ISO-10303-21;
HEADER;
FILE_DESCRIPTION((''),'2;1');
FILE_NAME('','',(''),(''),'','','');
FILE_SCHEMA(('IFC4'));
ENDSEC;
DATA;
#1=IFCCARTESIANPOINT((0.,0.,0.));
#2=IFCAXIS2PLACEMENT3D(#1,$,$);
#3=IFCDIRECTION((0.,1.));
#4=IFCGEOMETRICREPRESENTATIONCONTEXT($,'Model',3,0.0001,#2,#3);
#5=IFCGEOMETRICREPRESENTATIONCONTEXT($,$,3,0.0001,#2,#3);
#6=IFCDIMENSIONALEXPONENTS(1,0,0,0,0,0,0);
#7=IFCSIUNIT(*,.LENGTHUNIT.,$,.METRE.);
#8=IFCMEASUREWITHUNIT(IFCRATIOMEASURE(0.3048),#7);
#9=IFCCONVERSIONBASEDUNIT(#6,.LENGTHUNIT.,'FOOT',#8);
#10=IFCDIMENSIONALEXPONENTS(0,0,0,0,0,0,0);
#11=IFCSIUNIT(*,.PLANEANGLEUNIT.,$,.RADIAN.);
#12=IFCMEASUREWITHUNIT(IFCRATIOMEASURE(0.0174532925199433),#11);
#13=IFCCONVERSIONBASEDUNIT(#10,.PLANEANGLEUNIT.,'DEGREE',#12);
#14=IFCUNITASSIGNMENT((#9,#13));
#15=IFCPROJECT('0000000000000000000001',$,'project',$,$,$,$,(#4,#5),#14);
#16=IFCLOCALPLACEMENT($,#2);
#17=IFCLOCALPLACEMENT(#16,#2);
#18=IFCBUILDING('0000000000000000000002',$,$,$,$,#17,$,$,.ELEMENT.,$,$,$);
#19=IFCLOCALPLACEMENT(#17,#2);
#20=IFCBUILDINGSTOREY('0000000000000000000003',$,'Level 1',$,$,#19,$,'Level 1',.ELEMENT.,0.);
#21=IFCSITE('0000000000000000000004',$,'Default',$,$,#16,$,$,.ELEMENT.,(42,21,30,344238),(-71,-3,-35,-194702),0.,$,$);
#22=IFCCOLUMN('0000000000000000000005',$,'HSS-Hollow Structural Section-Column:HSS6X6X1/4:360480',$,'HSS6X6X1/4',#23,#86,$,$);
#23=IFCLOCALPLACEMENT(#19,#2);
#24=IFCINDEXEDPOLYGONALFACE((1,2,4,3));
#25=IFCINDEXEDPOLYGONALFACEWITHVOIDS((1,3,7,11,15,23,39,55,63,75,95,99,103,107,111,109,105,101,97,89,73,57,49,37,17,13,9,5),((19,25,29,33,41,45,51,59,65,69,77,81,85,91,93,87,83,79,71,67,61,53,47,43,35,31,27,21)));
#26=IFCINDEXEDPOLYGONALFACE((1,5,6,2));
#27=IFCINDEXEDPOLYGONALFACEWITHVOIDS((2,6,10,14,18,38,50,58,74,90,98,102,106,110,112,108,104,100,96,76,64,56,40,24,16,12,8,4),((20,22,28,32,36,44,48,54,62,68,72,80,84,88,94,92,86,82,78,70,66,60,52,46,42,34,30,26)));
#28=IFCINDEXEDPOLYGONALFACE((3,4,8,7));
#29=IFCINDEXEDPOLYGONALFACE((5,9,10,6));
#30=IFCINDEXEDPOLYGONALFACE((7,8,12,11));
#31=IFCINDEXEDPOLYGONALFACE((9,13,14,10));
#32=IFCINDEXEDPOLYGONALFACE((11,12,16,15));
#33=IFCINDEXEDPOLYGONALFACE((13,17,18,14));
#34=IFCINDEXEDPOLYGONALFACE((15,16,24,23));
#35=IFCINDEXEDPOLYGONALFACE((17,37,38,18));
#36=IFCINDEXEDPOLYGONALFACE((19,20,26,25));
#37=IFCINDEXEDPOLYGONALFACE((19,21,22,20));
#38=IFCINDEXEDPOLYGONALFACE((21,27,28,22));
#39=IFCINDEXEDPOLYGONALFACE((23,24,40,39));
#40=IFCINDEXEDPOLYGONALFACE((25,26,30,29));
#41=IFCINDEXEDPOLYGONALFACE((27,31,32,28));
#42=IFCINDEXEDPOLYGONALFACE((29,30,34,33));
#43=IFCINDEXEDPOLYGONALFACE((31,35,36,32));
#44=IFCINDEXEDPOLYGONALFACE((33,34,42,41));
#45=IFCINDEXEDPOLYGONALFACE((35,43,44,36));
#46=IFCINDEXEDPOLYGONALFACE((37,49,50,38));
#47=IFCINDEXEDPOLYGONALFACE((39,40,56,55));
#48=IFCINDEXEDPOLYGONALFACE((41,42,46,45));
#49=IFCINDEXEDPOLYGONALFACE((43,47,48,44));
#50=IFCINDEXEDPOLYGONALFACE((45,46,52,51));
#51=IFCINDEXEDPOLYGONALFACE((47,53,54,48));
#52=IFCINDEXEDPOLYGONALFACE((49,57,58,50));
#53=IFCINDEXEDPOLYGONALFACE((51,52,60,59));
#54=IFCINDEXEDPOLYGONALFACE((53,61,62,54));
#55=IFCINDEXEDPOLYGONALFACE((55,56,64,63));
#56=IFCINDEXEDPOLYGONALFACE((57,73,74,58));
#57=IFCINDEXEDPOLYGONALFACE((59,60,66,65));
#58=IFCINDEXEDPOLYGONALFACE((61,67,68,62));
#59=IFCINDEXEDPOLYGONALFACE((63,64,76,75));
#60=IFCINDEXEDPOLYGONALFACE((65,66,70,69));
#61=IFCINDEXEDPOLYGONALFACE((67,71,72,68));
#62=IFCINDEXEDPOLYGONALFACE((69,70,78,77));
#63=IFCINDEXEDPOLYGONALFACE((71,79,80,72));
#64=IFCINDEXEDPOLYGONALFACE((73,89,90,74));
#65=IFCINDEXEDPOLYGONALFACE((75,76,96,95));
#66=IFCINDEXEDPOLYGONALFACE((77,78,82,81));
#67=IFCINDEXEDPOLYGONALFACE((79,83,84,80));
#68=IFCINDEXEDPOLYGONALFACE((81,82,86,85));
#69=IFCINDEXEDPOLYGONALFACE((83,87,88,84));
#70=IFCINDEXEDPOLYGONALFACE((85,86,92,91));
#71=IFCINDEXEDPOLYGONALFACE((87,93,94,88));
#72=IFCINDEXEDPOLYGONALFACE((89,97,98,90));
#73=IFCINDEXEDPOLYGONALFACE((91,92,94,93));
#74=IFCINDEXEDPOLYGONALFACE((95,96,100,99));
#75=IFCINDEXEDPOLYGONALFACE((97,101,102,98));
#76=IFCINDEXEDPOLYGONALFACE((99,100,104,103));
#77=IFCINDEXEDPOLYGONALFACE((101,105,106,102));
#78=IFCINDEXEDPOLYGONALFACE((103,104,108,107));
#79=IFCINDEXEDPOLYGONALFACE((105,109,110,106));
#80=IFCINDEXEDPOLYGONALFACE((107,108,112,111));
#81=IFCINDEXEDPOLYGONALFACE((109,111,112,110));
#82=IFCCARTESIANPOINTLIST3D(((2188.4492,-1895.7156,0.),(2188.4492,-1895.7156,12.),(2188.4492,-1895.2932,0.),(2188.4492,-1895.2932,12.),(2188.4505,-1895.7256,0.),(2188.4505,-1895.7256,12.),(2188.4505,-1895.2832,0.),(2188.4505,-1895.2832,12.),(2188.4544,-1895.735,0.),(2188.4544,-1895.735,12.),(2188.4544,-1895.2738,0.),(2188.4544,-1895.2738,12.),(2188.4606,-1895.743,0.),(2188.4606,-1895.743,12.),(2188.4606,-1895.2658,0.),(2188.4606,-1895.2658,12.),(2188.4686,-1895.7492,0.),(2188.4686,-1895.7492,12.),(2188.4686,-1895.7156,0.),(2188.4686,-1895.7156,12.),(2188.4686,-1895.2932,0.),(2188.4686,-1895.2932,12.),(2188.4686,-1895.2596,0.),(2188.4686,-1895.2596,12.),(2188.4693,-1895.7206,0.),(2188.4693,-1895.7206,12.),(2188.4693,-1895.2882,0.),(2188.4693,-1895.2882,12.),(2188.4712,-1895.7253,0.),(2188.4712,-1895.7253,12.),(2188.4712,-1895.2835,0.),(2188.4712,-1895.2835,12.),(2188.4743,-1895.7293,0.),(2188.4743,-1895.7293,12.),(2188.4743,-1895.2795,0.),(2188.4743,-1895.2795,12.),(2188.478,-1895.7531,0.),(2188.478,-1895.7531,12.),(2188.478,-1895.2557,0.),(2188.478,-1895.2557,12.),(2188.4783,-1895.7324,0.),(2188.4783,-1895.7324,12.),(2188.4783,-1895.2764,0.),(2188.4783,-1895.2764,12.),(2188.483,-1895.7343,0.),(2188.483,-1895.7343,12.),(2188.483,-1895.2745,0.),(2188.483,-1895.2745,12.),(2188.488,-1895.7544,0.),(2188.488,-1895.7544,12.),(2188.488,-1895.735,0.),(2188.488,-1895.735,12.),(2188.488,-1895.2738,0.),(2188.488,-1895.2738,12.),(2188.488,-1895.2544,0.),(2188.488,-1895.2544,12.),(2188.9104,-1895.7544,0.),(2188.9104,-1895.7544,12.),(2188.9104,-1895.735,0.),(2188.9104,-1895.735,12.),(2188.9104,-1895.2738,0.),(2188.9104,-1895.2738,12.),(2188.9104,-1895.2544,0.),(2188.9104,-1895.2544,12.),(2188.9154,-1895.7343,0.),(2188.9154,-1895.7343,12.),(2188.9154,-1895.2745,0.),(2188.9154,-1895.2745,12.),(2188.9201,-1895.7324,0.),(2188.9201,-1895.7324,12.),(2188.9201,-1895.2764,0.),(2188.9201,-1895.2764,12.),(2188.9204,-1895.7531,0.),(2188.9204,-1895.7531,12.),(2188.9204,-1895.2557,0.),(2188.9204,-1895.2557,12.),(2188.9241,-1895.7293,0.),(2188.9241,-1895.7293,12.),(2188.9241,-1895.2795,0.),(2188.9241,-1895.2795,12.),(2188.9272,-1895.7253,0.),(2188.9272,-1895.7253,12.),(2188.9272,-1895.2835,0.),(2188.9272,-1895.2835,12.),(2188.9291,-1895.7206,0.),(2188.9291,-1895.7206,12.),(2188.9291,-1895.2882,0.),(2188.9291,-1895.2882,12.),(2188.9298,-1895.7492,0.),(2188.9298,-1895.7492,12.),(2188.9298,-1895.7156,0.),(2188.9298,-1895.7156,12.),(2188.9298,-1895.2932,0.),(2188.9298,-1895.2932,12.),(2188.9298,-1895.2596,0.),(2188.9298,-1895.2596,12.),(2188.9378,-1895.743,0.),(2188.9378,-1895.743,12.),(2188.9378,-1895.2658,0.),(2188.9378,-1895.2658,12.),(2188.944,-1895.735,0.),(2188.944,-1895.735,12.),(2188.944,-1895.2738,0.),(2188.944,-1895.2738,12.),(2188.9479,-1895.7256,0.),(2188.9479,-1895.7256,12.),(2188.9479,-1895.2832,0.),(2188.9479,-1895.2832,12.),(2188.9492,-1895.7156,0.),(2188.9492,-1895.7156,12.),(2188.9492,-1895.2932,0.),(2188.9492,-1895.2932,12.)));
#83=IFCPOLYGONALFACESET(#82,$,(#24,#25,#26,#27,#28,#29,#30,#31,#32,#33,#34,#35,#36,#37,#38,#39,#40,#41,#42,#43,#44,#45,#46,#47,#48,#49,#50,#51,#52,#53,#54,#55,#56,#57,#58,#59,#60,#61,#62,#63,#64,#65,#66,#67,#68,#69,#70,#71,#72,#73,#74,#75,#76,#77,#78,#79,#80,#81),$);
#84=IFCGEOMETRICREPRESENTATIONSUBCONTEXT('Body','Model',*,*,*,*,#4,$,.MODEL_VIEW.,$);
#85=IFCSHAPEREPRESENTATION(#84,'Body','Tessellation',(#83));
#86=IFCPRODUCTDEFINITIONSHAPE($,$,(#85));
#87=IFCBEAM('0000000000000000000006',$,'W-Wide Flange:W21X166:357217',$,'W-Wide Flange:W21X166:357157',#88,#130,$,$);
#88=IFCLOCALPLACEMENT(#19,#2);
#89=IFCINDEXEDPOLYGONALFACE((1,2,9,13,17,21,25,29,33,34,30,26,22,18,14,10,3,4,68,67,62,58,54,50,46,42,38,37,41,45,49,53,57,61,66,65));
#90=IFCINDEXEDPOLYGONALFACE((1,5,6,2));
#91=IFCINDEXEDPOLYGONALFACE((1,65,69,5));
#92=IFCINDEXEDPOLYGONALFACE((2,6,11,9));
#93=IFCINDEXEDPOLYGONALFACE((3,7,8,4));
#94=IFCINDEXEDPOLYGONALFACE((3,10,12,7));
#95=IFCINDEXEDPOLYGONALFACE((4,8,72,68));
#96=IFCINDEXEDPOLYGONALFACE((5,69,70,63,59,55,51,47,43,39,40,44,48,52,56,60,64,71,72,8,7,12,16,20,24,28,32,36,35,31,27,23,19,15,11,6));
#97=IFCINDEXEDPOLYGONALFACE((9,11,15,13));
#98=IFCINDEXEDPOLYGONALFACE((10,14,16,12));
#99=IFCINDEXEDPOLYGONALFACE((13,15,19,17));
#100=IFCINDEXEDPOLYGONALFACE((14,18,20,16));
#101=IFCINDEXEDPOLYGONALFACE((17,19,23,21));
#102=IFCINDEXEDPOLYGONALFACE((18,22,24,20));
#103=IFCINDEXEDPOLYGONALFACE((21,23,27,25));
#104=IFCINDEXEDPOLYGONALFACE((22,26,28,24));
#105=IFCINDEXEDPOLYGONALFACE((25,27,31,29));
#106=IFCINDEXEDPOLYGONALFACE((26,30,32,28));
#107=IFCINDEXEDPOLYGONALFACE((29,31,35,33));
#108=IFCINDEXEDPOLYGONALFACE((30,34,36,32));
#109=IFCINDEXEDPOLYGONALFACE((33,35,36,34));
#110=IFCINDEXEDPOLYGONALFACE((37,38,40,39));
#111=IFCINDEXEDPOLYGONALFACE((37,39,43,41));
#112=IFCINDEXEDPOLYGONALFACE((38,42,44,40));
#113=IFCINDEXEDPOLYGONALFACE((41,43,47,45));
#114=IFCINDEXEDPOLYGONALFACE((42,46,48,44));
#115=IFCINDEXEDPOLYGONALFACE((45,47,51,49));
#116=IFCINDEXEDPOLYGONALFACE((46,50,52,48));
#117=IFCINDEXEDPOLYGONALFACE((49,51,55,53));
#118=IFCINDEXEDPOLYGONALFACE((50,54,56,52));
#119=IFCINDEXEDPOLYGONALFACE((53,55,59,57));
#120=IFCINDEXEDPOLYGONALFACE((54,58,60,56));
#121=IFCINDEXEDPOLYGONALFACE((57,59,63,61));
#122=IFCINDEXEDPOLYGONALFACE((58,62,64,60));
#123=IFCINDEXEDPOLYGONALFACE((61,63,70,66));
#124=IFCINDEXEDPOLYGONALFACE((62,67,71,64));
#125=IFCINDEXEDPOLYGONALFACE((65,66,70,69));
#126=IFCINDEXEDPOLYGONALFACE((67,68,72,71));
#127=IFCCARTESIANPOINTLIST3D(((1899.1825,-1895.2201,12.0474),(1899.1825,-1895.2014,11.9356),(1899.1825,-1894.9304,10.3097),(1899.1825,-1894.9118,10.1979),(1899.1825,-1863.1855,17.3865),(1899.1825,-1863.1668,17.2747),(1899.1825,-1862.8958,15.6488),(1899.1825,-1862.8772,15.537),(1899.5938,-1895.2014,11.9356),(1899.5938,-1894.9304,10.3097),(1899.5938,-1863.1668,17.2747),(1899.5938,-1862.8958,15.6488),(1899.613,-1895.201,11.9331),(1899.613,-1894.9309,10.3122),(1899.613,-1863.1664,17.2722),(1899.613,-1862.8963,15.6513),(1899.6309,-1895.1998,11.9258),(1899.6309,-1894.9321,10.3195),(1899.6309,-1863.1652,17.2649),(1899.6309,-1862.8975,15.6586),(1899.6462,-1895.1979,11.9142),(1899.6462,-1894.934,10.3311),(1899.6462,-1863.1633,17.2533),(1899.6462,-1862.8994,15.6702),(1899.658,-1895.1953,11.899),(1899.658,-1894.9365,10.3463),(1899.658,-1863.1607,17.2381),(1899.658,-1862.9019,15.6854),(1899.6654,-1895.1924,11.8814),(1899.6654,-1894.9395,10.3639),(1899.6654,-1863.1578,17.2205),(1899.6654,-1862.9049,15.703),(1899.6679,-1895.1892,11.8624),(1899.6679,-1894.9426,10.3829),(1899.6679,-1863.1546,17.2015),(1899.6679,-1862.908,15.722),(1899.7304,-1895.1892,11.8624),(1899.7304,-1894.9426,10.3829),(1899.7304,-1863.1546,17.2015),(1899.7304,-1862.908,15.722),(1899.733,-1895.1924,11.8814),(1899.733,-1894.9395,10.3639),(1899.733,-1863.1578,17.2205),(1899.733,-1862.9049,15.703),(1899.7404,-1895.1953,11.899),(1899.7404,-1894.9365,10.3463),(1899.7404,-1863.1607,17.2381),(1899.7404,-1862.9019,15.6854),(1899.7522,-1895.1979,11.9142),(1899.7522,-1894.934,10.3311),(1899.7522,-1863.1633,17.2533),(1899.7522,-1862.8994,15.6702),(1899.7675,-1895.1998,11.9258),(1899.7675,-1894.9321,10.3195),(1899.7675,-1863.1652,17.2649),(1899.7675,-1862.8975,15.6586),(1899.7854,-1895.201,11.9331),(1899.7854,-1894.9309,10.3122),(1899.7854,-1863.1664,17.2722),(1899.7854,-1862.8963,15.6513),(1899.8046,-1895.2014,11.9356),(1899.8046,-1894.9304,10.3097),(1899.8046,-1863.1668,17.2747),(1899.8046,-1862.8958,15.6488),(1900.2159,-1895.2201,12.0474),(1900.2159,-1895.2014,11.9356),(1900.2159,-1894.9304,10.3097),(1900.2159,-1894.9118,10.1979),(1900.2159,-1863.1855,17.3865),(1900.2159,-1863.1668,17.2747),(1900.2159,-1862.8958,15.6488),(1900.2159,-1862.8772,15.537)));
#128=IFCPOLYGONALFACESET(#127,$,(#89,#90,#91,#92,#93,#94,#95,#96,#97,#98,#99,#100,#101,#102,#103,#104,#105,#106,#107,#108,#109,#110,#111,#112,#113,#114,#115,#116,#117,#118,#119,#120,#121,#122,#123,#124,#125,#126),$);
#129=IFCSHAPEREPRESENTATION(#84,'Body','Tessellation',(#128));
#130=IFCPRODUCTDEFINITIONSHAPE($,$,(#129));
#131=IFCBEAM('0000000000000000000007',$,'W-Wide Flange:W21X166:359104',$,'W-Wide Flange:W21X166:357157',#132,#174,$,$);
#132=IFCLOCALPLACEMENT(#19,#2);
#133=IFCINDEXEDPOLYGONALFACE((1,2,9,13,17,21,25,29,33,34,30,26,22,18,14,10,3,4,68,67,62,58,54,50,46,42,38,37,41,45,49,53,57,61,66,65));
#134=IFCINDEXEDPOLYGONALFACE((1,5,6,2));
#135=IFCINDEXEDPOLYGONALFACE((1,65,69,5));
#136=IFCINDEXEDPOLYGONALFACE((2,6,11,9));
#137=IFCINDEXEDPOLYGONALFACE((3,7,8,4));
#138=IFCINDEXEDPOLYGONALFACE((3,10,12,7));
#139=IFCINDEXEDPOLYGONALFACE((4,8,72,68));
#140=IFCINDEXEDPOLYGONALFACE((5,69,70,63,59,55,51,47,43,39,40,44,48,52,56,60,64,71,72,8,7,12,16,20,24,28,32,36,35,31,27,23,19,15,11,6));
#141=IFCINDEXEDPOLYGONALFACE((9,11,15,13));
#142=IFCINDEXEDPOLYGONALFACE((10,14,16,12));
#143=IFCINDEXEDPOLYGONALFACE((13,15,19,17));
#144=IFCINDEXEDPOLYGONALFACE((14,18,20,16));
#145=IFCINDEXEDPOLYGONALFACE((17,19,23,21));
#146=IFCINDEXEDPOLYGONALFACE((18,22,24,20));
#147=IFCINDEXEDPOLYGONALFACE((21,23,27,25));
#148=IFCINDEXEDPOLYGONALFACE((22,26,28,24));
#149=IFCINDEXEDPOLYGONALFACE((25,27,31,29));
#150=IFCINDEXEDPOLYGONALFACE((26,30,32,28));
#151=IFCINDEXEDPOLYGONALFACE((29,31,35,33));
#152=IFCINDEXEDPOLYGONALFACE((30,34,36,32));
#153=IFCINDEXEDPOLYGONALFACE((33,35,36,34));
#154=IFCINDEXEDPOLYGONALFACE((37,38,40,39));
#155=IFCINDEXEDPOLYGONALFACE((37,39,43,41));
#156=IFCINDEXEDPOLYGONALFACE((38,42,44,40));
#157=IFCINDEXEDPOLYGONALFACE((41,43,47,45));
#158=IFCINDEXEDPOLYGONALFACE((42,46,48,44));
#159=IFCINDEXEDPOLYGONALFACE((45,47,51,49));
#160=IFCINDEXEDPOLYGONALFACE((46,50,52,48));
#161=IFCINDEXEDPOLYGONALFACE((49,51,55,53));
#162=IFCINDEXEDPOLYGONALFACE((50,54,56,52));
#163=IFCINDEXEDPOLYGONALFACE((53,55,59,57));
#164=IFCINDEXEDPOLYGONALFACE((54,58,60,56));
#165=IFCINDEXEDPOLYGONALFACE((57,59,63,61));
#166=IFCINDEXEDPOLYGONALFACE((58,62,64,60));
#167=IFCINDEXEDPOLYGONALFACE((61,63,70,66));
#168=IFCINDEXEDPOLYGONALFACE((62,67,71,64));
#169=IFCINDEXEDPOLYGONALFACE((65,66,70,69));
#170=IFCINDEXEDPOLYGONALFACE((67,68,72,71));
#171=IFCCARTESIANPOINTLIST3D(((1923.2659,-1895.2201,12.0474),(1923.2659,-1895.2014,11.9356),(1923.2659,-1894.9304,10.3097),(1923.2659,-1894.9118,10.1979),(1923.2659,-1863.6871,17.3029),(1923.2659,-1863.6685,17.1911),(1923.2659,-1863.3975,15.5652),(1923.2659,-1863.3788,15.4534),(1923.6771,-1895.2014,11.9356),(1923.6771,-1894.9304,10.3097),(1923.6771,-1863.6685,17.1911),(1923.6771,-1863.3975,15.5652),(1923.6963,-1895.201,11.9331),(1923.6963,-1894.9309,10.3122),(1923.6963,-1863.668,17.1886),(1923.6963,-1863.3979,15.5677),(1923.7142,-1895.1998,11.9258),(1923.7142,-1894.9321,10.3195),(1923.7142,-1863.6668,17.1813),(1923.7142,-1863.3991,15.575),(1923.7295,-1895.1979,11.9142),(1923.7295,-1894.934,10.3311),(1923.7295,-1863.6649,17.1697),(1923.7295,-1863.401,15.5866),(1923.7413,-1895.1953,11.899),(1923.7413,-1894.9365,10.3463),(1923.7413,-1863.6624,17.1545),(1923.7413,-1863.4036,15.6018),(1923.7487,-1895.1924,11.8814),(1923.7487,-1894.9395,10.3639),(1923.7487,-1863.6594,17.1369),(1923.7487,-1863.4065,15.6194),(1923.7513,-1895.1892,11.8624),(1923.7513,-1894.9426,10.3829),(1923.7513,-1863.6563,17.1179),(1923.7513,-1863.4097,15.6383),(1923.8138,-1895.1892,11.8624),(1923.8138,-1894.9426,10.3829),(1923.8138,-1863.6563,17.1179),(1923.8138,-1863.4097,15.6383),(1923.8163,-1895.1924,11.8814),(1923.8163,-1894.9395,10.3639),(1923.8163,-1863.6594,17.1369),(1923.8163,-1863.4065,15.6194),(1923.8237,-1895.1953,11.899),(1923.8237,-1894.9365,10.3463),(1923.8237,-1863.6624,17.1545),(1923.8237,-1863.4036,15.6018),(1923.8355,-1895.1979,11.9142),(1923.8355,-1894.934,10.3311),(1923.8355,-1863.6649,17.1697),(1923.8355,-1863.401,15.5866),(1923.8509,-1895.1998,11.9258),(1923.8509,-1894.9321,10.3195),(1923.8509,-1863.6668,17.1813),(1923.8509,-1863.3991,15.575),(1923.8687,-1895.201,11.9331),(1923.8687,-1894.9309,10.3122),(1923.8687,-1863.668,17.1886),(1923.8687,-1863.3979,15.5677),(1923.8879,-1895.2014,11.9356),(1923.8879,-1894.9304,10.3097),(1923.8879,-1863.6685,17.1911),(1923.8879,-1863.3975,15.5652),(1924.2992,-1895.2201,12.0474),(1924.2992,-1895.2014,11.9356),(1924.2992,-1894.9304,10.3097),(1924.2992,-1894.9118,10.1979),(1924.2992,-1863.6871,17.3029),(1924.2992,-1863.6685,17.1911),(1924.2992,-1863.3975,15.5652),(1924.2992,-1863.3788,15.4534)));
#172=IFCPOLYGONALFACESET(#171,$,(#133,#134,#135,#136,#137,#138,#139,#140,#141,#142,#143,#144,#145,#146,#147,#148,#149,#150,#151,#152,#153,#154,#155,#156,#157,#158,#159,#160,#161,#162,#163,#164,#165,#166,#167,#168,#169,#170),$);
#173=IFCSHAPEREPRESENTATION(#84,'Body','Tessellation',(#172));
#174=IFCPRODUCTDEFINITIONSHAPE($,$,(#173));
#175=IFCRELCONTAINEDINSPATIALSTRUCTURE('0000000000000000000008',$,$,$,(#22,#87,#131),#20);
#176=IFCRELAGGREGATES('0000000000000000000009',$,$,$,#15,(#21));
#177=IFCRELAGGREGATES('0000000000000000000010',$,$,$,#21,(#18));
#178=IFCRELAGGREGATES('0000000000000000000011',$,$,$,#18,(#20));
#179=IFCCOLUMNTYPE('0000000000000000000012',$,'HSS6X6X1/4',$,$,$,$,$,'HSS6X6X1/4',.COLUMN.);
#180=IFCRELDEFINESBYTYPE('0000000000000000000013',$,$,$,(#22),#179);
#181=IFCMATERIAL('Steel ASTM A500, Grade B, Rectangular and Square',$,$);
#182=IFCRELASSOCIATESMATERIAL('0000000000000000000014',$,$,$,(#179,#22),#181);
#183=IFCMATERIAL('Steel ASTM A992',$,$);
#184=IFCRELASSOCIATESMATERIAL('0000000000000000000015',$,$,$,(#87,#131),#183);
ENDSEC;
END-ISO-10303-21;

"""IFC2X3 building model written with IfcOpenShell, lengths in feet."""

from ifc_helpers import new_model, entity, si_unit, converted_unit, direction, frame, frame_2d, origin, place, context, subcontext, project, spatial, polyline, circle_curve, parameter, trimmed, segment, composite_curve, i_section, outline, extrude, source, transform, mapped, material, type_object, type_shapes, element, save


model = new_model("IFC2X3")

# Units and contexts
model_context = context("Model", 3, precision=0.0001, world=origin(), true_north=direction((0.0, 1.0)))
context_of_model = context(None, 3, precision=0.0001, world=origin(), true_north=direction((0.0, 1.0)))
body_context = subcontext(model_context, "Body", "Model", "MODEL_VIEW")
ifc_project = project(units=[converted_unit("LENGTHUNIT", "FOOT", entity("IfcRatioMeasure", 0.3048), si_unit("LENGTHUNIT", "METRE"), dimensions=[1, 0, 0, 0, 0, 0, 0]), converted_unit("PLANEANGLEUNIT", "DEGREE", entity("IfcRatioMeasure", 0.0174532925199433), si_unit("PLANEANGLEUNIT", "RADIAN"), dimensions=[0, 0, 0, 0, 0, 0, 0])], contexts=[model_context, context_of_model])

# Site, building, storey
site_placement = place(None, origin())
site = spatial("IfcSite", under=ifc_project, at=site_placement, Name="Default", CompositionType="ELEMENT", RefLatitude=(42, 21, 30, 344238), RefLongitude=(-71, -3, -35, -194702), RefElevation=0.0)
building_placement = place(site_placement, origin())
building = spatial("IfcBuilding", under=site, at=building_placement, CompositionType="ELEMENT")
storey_placement = place(building_placement, origin())
storey = spatial("IfcBuildingStorey", under=building, at=storey_placement, Name="Level 1", LongName="Level 1", CompositionType="ELEMENT", Elevation=0.0)

# Column
ifc_material_1 = material(Name="Steel ASTM A500, Grade B, Rectangular and Square")
column_type = type_object("IfcColumnType", Name="HSS6X6X1/4", ElementType="HSS6X6X1/4", PredefinedType="COLUMN", material=ifc_material_1)
shared_shape = source(origin(), body_context, "Body", "SweptSolid", [
    extrude(outline(composite_curve([segment(polyline([(-0.2112, -0.25), (0.2112, -0.25)]), True, "CONTINUOUS"), segment(trimmed(circle_curve(frame_2d((0.2112, -0.2112), x_axis=(-1.0, 0.0)), 0.0388), [parameter(90.0)], [parameter(180.0)], True, "PARAMETER"), True, "CONTINUOUS"), segment(polyline([(0.25, -0.2112), (0.25, 0.2112)]), True, "CONTINUOUS"), segment(trimmed(circle_curve(frame_2d((0.2112, 0.2112), x_axis=(-1.0, 0.0)), 0.0388), [parameter(180.0)], [parameter(270.0)], True, "PARAMETER"), True, "CONTINUOUS"), segment(polyline([(0.2112, 0.25), (-0.2112, 0.25)]), True, "CONTINUOUS"), segment(trimmed(circle_curve(frame_2d((-0.2112, 0.2112), x_axis=(-1.0, 0.0)), 0.0388), [parameter(270.0)], [parameter(360.0)], True, "PARAMETER"), True, "CONTINUOUS"), segment(polyline([(-0.25, 0.2112), (-0.25, -0.2112)]), True, "CONTINUOUS"), segment(trimmed(circle_curve(frame_2d((-0.2112, -0.2112), x_axis=(-1.0, 0.0)), 0.0388), [parameter(360.0)], [parameter(90.0)], True, "PARAMETER"), True, "CONTINUOUS")], self_intersect=False), holes=[composite_curve([segment(trimmed(circle_curve(frame_2d((-0.2112, -0.2112), x_axis=(-1.0, 0.0)), 0.0194), [parameter(0.0)], [parameter(90.0)], True, "PARAMETER"), False, "CONTINUOUS"), segment(polyline([(-0.2306, -0.2112), (-0.2306, 0.2112)]), True, "CONTINUOUS"), segment(trimmed(circle_curve(frame_2d((-0.2112, 0.2112), x_axis=(-1.0, 0.0)), 0.0194), [parameter(270.0)], [parameter(360.0)], True, "PARAMETER"), False, "CONTINUOUS"), segment(polyline([(-0.2112, 0.2306), (0.2112, 0.2306)]), True, "CONTINUOUS"), segment(trimmed(circle_curve(frame_2d((0.2112, 0.2112), x_axis=(-1.0, 0.0)), 0.0194), [parameter(180.0)], [parameter(270.0)], True, "PARAMETER"), False, "CONTINUOUS"), segment(polyline([(0.2306, 0.2112), (0.2306, -0.2112)]), True, "CONTINUOUS"), segment(trimmed(circle_curve(frame_2d((0.2112, -0.2112), x_axis=(-1.0, 0.0)), 0.0194), [parameter(90.0)], [parameter(180.0)], True, "PARAMETER"), False, "CONTINUOUS"), segment(polyline([(0.2112, -0.2306), (-0.2112, -0.2306)]), True, "CONTINUOUS")], self_intersect=False)]), frame((0.0, 0.0, 0.0), z_axis=(0.0, 0.0, 1.0), x_axis=(-1.0, 0.0, 0.0)), (0.0, 0.0, 1.0), 12.0),
])
type_shapes(column_type, [shared_shape])
for number, where, z_axis, x_axis, name in (
    (1, (2188.6992, -1895.5044, 0.0), (0.0, 0.0, 1.0), (-1.0, 0.0, 0.0), "HSS-Hollow Structural Section-Column:HSS6X6X1/4:360480"),
):
    element("IfcColumn", number, at=place(storey_placement, frame(where, z_axis=z_axis, x_axis=x_axis)), inside=storey, type_object=column_type, material=ifc_material_1, Name=name, ObjectType="HSS6X6X1/4", context=body_context, shape_type="MappedRepresentation", body=[
        mapped(shared_shape, transform((0.0, 0.0, 0.0), scale=1.0)),
    ])

# Beams
ifc_material_2 = material(Name="Steel ASTM A992")
beam_1_placement = place(storey_placement, frame((1899.6992, -1895.6585, 11.9743), z_axis=(0.0, -0.164399, 0.986394), x_axis=(0.0, 0.986394, 0.164399)))
element("IfcBeam", 2, at=beam_1_placement, inside=storey, material=ifc_material_2, Name="W-Wide Flange:W21X166:357217", ObjectType="W-Wide Flange:W21X166:357157", context=body_context, shape_type="SweptSolid", body=[
    extrude(i_section(OverallWidth=1.0333, OverallDepth=1.875, WebThickness=0.0625, FlangeThickness=0.1133, FilletRadius=0.0742, at=frame_2d((0.0, 0.0), x_axis=(0.0, 1.0))), frame((0.4445, 0.0, -0.9375), z_axis=(1.0, 0.0, 0.0), x_axis=(0.0, 0.0, -1.0)), (0.0, 0.0, 1.0), 32.4765),
])
beam_2_placement = place(storey_placement, frame((1923.7825, -1895.6585, 11.9743), z_axis=(0.0, -0.164399, 0.986394), x_axis=(0.0, 0.986394, 0.164399)))
element("IfcBeam", 3, at=beam_2_placement, inside=storey, material=ifc_material_2, Name="W-Wide Flange:W21X166:359104", ObjectType="W-Wide Flange:W21X166:357157", context=body_context, shape_type="SweptSolid", body=[
    extrude(i_section(OverallWidth=1.0333, OverallDepth=1.875, WebThickness=0.0625, FlangeThickness=0.1133, FilletRadius=0.0742, at=frame_2d((0.0, 0.0), x_axis=(0.0, 1.0))), frame((0.4445, 0.0, -0.9375), z_axis=(1.0, 0.0, 0.0), x_axis=(0.0, 0.0, -1.0)), (0.0, 0.0, 1.0), 31.9679),
])

save(model, "model.ifc")
